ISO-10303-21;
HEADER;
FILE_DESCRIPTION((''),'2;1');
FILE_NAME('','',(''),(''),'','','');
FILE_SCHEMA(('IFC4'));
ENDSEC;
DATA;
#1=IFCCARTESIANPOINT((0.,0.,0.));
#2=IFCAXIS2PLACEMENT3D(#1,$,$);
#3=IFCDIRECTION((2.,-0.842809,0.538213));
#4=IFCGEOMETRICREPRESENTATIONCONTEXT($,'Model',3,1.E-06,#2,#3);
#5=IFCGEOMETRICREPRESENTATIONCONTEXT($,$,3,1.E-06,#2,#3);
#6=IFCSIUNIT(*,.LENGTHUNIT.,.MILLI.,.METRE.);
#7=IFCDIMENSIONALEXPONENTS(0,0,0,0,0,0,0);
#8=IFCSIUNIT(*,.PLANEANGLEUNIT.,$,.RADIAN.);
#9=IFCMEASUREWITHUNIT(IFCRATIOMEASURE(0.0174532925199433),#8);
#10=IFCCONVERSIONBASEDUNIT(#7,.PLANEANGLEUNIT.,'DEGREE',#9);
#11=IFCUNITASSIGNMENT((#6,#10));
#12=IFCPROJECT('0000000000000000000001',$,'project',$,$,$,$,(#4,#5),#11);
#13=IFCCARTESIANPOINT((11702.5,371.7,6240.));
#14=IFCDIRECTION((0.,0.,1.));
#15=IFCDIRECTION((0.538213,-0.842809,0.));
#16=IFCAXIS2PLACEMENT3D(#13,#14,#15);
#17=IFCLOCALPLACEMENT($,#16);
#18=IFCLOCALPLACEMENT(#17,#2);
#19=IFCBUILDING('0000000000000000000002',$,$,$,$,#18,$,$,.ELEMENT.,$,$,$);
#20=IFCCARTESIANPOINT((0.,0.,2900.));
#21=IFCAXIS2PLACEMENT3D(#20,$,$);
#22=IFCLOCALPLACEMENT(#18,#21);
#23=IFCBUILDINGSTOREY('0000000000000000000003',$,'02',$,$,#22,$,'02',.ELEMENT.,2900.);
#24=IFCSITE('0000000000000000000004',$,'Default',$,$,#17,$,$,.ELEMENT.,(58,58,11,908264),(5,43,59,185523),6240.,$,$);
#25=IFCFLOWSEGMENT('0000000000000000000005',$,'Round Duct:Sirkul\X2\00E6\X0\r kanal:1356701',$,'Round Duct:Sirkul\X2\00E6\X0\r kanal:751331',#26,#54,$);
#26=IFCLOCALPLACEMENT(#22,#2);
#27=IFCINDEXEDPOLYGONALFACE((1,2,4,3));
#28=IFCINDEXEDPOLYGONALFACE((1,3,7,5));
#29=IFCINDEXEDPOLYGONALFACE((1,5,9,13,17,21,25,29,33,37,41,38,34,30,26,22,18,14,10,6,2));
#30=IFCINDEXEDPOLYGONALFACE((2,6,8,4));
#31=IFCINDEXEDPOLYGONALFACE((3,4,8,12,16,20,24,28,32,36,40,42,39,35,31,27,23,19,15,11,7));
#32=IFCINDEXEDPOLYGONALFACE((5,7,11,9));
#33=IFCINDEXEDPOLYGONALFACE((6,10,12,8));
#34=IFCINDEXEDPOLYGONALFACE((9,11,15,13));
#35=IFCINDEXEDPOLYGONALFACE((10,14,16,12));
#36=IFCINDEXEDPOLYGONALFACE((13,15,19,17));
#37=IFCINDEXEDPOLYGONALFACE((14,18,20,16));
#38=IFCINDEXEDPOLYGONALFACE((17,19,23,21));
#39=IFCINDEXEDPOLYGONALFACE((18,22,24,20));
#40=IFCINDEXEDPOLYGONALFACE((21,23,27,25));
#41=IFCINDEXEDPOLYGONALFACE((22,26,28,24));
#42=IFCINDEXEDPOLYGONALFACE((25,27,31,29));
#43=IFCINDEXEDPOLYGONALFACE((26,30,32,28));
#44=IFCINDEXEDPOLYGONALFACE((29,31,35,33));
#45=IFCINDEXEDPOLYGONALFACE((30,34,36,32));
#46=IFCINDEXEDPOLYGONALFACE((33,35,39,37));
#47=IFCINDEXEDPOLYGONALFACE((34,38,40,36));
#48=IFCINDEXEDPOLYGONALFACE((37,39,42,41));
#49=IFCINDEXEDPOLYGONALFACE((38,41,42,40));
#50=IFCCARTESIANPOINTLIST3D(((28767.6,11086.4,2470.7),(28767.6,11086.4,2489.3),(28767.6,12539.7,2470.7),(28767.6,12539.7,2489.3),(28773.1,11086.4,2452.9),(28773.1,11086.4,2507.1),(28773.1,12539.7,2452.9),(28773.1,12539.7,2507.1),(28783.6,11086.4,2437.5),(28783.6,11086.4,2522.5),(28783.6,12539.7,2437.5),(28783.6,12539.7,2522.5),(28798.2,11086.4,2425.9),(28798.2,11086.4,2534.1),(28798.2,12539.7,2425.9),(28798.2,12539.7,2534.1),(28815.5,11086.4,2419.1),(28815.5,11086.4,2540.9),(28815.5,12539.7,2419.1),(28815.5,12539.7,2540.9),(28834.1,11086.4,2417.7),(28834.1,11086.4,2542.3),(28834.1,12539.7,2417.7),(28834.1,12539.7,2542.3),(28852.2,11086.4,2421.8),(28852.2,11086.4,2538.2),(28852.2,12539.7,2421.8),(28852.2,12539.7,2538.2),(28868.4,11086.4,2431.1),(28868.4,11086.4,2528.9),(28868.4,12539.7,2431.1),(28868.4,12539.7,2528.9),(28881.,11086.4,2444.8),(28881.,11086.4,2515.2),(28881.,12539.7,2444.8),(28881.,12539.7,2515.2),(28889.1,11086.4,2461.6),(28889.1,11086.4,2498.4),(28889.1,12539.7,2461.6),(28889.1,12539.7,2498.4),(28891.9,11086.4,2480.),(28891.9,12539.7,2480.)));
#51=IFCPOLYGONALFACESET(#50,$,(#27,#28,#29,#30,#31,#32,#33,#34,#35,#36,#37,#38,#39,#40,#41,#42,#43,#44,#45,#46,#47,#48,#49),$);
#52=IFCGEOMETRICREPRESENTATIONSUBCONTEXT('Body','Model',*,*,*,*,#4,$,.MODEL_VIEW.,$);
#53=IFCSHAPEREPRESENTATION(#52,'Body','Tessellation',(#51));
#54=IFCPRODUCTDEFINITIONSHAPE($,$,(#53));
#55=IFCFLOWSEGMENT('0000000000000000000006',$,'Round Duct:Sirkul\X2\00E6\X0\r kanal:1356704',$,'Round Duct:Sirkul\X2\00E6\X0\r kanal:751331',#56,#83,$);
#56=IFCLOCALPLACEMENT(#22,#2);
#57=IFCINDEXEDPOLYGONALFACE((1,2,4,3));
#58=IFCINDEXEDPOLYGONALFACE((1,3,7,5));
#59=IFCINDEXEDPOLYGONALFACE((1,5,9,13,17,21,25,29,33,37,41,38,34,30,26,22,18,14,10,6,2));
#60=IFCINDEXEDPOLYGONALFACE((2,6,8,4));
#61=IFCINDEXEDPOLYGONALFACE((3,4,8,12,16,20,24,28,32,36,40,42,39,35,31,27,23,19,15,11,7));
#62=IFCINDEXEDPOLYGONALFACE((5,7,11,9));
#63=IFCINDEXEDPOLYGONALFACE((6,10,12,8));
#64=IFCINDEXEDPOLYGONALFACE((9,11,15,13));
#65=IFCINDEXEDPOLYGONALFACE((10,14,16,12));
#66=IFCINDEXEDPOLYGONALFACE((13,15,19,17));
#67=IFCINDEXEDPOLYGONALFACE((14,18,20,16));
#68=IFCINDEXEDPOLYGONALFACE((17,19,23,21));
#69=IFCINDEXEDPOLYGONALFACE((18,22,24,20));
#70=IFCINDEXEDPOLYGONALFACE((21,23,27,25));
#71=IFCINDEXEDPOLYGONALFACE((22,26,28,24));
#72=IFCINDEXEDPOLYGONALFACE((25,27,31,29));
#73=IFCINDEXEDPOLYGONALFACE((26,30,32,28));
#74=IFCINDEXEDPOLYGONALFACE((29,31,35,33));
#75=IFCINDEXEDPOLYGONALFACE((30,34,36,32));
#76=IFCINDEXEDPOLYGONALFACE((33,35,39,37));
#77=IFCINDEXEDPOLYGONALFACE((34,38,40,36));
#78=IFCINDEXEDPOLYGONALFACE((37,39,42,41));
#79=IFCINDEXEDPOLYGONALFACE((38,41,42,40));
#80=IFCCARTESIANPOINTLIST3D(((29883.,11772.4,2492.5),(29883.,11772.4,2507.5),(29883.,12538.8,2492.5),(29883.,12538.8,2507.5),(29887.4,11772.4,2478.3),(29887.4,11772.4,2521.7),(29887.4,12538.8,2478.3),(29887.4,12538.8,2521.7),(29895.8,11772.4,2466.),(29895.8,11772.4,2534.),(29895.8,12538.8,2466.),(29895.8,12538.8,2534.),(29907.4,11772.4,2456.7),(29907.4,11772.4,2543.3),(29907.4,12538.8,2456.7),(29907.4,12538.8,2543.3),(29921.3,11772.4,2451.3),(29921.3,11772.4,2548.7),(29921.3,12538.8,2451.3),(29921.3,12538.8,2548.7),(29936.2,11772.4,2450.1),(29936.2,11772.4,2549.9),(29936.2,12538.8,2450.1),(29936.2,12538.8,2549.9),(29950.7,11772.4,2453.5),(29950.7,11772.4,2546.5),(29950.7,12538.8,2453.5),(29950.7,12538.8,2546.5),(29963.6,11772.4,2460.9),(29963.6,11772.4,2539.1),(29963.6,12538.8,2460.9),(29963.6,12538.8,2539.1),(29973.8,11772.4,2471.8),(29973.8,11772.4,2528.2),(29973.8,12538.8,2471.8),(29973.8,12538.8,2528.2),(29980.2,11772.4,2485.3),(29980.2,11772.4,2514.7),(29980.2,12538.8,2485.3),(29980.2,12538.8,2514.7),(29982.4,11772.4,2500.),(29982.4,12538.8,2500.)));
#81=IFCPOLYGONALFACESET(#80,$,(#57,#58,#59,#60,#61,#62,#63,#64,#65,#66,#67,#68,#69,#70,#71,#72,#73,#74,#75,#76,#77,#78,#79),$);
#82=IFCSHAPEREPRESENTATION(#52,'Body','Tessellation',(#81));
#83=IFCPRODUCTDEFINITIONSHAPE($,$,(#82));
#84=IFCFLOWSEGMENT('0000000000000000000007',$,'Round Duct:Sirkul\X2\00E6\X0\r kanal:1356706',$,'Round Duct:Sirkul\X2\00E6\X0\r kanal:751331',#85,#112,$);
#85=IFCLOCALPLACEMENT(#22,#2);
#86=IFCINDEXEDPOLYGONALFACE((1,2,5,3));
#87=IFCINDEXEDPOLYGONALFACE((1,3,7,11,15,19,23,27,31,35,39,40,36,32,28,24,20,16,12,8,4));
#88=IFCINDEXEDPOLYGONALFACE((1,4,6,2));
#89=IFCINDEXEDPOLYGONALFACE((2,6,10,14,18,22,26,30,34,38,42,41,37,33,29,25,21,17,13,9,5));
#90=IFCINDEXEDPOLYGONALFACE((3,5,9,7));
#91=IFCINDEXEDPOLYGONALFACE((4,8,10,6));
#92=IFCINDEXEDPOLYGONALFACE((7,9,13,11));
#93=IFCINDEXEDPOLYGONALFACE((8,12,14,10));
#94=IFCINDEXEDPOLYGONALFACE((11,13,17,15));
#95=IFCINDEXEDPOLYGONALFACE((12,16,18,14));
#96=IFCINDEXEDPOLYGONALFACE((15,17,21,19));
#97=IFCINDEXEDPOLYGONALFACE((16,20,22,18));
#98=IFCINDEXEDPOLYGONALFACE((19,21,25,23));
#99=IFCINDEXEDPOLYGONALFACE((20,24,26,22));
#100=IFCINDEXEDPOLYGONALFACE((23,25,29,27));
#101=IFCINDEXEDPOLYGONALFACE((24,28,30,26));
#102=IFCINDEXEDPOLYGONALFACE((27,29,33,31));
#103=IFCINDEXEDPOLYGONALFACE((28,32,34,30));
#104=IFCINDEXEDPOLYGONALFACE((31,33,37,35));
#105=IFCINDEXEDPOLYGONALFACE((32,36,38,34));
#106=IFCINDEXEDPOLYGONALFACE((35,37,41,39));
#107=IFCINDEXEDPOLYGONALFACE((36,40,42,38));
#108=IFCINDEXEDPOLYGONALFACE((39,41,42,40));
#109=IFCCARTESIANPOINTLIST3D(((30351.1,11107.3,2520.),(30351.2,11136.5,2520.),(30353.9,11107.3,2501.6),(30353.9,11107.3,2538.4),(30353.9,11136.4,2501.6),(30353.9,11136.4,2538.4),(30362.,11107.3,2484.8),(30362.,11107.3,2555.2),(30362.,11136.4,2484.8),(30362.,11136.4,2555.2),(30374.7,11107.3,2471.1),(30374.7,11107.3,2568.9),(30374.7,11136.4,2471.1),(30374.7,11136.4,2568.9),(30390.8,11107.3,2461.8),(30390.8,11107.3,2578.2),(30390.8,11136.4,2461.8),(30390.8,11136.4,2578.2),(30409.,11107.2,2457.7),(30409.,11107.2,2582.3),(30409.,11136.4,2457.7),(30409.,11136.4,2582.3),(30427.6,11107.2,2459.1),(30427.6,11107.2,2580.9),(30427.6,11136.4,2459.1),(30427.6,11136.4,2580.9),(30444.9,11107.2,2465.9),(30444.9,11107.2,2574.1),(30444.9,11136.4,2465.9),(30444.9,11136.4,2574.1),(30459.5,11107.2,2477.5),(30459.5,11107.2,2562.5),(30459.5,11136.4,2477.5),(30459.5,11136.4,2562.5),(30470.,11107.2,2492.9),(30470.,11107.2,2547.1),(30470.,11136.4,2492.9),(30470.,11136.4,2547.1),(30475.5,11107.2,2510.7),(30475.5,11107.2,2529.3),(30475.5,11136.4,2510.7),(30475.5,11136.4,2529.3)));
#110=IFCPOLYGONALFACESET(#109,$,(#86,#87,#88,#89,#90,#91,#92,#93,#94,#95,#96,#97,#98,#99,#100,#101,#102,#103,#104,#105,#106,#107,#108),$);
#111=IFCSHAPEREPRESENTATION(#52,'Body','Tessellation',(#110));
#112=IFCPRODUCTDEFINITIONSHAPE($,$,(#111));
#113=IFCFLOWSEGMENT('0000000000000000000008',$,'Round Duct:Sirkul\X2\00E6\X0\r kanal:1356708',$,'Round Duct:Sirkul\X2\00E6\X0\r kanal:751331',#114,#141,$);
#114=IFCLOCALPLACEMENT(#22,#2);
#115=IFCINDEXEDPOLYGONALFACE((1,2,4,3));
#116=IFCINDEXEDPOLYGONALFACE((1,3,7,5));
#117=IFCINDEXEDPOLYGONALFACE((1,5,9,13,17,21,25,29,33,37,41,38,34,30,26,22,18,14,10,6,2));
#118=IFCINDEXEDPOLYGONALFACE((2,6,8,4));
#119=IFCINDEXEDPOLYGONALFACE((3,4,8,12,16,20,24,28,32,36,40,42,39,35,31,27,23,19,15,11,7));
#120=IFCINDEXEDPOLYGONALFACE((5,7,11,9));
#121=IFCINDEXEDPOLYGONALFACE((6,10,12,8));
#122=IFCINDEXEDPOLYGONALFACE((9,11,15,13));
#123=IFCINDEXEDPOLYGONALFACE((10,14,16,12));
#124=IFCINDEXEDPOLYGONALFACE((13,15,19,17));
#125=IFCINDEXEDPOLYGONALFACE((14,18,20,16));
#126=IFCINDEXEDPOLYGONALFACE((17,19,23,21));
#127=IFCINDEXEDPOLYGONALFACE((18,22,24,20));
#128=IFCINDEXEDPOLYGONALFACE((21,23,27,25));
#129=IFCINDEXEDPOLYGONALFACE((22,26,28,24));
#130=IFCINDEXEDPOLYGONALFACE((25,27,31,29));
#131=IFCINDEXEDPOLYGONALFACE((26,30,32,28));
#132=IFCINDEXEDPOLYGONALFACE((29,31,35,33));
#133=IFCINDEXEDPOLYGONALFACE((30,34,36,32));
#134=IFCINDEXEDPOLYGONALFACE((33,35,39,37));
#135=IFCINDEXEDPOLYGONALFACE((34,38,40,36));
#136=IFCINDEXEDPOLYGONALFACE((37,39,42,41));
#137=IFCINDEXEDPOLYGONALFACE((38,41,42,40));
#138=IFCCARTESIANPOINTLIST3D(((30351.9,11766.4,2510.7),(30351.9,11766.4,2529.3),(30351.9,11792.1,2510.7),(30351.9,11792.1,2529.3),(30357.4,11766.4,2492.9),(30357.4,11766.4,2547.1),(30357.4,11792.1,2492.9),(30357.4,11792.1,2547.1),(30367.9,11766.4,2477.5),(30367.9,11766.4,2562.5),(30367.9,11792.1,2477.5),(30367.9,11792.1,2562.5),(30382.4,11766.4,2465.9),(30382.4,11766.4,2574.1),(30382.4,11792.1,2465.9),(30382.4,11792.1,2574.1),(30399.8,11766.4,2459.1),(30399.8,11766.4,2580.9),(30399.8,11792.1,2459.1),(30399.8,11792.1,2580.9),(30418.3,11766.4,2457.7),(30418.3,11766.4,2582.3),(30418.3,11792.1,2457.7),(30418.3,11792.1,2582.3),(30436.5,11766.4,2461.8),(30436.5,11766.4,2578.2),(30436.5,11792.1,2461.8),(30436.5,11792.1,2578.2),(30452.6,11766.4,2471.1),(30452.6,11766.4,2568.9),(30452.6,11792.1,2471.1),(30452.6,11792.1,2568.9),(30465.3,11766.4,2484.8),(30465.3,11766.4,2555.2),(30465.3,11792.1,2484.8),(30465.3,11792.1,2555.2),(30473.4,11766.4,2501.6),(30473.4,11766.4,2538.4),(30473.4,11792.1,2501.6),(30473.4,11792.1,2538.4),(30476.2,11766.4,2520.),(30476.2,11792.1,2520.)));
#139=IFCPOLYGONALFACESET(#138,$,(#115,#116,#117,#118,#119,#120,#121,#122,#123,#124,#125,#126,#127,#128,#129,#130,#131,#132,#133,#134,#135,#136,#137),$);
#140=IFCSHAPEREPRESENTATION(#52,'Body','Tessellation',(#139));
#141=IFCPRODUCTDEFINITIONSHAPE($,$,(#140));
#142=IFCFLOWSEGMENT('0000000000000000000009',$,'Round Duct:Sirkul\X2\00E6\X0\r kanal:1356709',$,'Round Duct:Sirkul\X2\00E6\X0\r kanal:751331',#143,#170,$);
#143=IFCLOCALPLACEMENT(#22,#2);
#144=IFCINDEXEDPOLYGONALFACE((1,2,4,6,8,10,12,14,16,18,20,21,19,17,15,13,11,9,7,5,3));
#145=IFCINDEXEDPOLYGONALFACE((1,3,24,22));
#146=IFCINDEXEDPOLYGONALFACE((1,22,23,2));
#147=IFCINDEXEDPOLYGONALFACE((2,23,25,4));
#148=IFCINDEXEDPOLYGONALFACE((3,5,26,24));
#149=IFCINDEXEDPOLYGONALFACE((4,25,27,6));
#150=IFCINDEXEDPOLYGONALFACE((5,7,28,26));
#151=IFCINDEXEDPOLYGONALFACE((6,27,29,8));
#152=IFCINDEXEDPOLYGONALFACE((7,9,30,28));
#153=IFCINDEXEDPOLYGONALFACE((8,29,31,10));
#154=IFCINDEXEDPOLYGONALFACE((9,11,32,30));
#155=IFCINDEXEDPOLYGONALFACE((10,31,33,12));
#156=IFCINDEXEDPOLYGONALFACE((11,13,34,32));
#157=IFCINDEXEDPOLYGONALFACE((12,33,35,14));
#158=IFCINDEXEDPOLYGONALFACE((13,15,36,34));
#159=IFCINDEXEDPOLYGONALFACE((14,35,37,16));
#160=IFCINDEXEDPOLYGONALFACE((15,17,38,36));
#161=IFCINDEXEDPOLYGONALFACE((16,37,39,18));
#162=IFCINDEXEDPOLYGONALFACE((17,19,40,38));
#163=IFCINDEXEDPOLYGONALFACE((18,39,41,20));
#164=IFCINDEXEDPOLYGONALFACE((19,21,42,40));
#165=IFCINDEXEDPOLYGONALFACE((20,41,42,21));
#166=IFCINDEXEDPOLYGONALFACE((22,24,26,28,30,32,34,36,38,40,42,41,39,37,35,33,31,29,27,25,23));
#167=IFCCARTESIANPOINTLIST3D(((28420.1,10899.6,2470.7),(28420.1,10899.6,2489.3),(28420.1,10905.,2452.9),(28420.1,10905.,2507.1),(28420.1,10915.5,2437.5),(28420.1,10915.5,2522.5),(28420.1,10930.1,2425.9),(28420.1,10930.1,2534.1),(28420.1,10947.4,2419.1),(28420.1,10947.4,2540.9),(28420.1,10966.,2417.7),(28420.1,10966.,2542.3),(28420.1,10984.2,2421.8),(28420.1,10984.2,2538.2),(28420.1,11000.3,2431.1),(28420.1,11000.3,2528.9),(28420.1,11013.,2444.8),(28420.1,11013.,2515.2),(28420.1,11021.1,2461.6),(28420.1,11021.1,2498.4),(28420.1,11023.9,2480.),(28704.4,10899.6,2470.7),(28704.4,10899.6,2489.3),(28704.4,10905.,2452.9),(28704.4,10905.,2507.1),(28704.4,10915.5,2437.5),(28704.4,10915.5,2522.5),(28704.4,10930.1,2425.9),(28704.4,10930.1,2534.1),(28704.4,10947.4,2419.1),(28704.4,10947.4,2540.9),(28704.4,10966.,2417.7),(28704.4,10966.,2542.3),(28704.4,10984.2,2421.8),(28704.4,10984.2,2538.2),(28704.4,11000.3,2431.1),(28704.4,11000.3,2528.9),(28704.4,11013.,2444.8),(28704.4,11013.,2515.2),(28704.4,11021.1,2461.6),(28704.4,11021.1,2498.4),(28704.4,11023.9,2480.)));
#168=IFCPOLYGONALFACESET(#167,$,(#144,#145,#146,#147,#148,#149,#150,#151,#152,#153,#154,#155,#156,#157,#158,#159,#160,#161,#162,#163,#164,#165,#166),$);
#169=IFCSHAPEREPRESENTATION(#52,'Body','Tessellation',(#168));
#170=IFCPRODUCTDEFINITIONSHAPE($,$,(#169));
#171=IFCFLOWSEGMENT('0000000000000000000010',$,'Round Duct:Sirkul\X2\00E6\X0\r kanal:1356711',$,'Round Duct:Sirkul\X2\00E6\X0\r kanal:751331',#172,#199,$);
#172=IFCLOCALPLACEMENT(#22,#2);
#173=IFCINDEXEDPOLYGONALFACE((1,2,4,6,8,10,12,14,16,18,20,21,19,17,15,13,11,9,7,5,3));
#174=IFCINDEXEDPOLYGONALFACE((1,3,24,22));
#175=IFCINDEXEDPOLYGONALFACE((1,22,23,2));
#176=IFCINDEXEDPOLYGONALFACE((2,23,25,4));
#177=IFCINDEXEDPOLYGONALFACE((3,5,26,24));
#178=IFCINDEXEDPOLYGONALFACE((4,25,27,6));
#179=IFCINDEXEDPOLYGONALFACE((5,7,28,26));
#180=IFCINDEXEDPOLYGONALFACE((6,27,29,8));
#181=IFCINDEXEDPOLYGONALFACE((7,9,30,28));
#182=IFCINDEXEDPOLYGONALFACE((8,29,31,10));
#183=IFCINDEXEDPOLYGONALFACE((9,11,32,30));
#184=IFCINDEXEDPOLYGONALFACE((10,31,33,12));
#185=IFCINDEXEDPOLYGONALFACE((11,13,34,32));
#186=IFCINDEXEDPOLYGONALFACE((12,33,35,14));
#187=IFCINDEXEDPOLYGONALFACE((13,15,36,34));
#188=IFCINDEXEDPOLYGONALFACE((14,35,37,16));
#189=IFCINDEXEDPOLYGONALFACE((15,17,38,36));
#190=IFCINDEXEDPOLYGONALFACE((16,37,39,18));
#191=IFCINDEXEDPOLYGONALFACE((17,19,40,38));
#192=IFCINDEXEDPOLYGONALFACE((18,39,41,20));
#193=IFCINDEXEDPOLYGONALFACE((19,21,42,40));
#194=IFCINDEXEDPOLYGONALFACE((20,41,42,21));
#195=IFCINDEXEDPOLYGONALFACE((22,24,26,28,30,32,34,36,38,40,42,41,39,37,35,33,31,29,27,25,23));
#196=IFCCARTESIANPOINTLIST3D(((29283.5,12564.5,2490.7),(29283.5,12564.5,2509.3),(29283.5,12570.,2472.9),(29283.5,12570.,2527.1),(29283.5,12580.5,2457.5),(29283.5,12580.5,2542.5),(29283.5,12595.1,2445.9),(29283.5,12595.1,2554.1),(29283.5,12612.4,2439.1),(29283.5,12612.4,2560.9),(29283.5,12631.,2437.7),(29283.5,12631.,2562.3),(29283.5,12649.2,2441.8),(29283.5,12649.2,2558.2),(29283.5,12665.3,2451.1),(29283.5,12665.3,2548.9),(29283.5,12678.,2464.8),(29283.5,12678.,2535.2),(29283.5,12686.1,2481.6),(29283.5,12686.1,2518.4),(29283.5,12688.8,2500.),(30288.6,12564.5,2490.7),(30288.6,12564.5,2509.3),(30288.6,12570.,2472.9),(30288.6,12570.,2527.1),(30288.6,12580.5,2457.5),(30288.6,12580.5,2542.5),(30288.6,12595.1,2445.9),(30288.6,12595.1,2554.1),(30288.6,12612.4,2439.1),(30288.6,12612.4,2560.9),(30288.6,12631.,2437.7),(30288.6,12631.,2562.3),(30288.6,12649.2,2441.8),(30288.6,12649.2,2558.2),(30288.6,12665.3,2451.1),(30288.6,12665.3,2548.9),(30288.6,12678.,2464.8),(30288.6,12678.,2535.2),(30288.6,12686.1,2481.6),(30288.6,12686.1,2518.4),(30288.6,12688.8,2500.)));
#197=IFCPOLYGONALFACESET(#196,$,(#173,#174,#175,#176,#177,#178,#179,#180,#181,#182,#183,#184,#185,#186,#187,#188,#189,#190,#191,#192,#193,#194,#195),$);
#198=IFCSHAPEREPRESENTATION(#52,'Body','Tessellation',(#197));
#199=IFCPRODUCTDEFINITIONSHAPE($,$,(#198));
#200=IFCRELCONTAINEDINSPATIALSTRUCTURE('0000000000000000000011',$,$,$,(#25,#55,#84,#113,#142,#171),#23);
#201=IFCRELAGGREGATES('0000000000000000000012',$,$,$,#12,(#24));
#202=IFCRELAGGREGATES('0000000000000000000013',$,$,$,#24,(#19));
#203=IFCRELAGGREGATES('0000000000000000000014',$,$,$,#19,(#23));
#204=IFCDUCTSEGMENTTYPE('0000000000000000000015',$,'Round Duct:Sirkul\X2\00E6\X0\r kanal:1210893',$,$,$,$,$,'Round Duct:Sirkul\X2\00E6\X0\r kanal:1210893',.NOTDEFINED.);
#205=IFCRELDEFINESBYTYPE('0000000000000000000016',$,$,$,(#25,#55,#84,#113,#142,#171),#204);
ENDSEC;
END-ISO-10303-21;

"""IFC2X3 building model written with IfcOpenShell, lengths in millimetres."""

from ifc_helpers import new_model, entity, si_unit, converted_unit, direction, frame, origin, origin_2d_with_axis, place, context, subcontext, project, spatial, circle, extrude, type_object, element, save


model = new_model("IFC2X3")

# Units and contexts
model_context = context("Model", 3, precision=1e-06, world=origin(), true_north=direction((2.0, -0.842809, 0.538213)))
context_of_model = context(None, 3, precision=1e-06, world=origin(), true_north=direction((2.0, -0.842809, 0.538213)))
body_context = subcontext(model_context, "Body", "Model", "MODEL_VIEW")
ifc_project = project(units=[si_unit("LENGTHUNIT", "METRE", prefix="MILLI"), converted_unit("PLANEANGLEUNIT", "DEGREE", entity("IfcRatioMeasure", 0.0174532925199433), si_unit("PLANEANGLEUNIT", "RADIAN"), dimensions=[0, 0, 0, 0, 0, 0, 0])], contexts=[model_context, context_of_model])

# Site, building, storey
site_placement = place(None, frame((11702.5, 371.7, 6240.0), z_axis=(0.0, 0.0, 1.0), x_axis=(0.538213, -0.842809, 0.0)))
site = spatial("IfcSite", under=ifc_project, at=site_placement, Name="Default", CompositionType="ELEMENT", RefLatitude=(58, 58, 11, 908264), RefLongitude=(5, 43, 59, 185523), RefElevation=6240.0)
building_placement = place(site_placement, origin())
building = spatial("IfcBuilding", under=site, at=building_placement, CompositionType="ELEMENT")
storey_placement = place(building_placement, frame((0.0, 0.0, 2900.0)))
storey = spatial("IfcBuildingStorey", under=building, at=storey_placement, Name="02", LongName="02", CompositionType="ELEMENT", Elevation=2900.0)

# Flow segments
duct_segment_type = type_object("IfcDuctSegmentType", Name="Round Duct:Sirkulær kanal:1210893", ElementType="Round Duct:Sirkulær kanal:1210893", PredefinedType="NOTDEFINED")
flow_segment_1_placement = place(storey_placement, origin())
element("IfcFlowSegment", 1, at=flow_segment_1_placement, inside=storey, type_object=duct_segment_type, Name="Round Duct:Sirkulær kanal:1356701", ObjectType="Round Duct:Sirkulær kanal:751331", context=body_context, shape_type="SweptSolid", body=[
    extrude(circle(Radius=62.5, at=origin_2d_with_axis()), frame((28829.4, 11086.4, 2480.0), z_axis=(0.0, 1.0, 0.0), x_axis=(1.0, 0.0, 0.0)), (0.0, 0.0, 1.0), 1453.3),
])
flow_segment_2_placement = place(storey_placement, origin())
element("IfcFlowSegment", 2, at=flow_segment_2_placement, inside=storey, type_object=duct_segment_type, Name="Round Duct:Sirkulær kanal:1356704", ObjectType="Round Duct:Sirkulær kanal:751331", context=body_context, shape_type="SweptSolid", body=[
    extrude(circle(Radius=50.0, at=origin_2d_with_axis()), frame((29932.4, 11772.4, 2500.0), z_axis=(0.0, 1.0, 0.0), x_axis=(1.0, 0.0, 0.0)), (0.0, 0.0, 1.0), 766.5),
])
flow_segment_3_placement = place(storey_placement, origin())
element("IfcFlowSegment", 3, at=flow_segment_3_placement, inside=storey, type_object=duct_segment_type, Name="Round Duct:Sirkulær kanal:1356706", ObjectType="Round Duct:Sirkulær kanal:751331", context=body_context, shape_type="SweptSolid", body=[
    extrude(circle(Radius=62.5, at=origin_2d_with_axis()), frame((30413.6, 11107.2, 2520.0), z_axis=(0.000626, 1.0, 0.0), x_axis=(-1.0, 0.000626, 0.0)), (0.0, 0.0, 1.0), 29.2),
])
flow_segment_4_placement = place(storey_placement, origin())
element("IfcFlowSegment", 4, at=flow_segment_4_placement, inside=storey, type_object=duct_segment_type, Name="Round Duct:Sirkulær kanal:1356708", ObjectType="Round Duct:Sirkulær kanal:751331", context=body_context, shape_type="SweptSolid", body=[
    extrude(circle(Radius=62.5, at=origin_2d_with_axis()), frame((30413.7, 11766.4, 2520.0), z_axis=(0.0, 1.0, 0.0), x_axis=(1.0, 0.0, 0.0)), (0.0, 0.0, 1.0), 25.7),
])
flow_segment_5_placement = place(storey_placement, origin())
element("IfcFlowSegment", 5, at=flow_segment_5_placement, inside=storey, type_object=duct_segment_type, Name="Round Duct:Sirkulær kanal:1356709", ObjectType="Round Duct:Sirkulær kanal:751331", context=body_context, shape_type="SweptSolid", body=[
    extrude(circle(Radius=62.5, at=origin_2d_with_axis()), frame((28420.1, 10961.4, 2480.0), z_axis=(1.0, 0.0, 0.0), x_axis=(0.0, 1.0, 0.0)), (0.0, 0.0, 1.0), 284.4),
])
flow_segment_6_placement = place(storey_placement, origin())
element("IfcFlowSegment", 6, at=flow_segment_6_placement, inside=storey, type_object=duct_segment_type, Name="Round Duct:Sirkulær kanal:1356711", ObjectType="Round Duct:Sirkulær kanal:751331", context=body_context, shape_type="SweptSolid", body=[
    extrude(circle(Radius=62.5, at=origin_2d_with_axis()), frame((29283.5, 12626.3, 2500.0), z_axis=(1.0, 0.0, 0.0), x_axis=(0.0, 1.0, 0.0)), (0.0, 0.0, 1.0), 1005.1),
])

save(model, "model.ifc")
